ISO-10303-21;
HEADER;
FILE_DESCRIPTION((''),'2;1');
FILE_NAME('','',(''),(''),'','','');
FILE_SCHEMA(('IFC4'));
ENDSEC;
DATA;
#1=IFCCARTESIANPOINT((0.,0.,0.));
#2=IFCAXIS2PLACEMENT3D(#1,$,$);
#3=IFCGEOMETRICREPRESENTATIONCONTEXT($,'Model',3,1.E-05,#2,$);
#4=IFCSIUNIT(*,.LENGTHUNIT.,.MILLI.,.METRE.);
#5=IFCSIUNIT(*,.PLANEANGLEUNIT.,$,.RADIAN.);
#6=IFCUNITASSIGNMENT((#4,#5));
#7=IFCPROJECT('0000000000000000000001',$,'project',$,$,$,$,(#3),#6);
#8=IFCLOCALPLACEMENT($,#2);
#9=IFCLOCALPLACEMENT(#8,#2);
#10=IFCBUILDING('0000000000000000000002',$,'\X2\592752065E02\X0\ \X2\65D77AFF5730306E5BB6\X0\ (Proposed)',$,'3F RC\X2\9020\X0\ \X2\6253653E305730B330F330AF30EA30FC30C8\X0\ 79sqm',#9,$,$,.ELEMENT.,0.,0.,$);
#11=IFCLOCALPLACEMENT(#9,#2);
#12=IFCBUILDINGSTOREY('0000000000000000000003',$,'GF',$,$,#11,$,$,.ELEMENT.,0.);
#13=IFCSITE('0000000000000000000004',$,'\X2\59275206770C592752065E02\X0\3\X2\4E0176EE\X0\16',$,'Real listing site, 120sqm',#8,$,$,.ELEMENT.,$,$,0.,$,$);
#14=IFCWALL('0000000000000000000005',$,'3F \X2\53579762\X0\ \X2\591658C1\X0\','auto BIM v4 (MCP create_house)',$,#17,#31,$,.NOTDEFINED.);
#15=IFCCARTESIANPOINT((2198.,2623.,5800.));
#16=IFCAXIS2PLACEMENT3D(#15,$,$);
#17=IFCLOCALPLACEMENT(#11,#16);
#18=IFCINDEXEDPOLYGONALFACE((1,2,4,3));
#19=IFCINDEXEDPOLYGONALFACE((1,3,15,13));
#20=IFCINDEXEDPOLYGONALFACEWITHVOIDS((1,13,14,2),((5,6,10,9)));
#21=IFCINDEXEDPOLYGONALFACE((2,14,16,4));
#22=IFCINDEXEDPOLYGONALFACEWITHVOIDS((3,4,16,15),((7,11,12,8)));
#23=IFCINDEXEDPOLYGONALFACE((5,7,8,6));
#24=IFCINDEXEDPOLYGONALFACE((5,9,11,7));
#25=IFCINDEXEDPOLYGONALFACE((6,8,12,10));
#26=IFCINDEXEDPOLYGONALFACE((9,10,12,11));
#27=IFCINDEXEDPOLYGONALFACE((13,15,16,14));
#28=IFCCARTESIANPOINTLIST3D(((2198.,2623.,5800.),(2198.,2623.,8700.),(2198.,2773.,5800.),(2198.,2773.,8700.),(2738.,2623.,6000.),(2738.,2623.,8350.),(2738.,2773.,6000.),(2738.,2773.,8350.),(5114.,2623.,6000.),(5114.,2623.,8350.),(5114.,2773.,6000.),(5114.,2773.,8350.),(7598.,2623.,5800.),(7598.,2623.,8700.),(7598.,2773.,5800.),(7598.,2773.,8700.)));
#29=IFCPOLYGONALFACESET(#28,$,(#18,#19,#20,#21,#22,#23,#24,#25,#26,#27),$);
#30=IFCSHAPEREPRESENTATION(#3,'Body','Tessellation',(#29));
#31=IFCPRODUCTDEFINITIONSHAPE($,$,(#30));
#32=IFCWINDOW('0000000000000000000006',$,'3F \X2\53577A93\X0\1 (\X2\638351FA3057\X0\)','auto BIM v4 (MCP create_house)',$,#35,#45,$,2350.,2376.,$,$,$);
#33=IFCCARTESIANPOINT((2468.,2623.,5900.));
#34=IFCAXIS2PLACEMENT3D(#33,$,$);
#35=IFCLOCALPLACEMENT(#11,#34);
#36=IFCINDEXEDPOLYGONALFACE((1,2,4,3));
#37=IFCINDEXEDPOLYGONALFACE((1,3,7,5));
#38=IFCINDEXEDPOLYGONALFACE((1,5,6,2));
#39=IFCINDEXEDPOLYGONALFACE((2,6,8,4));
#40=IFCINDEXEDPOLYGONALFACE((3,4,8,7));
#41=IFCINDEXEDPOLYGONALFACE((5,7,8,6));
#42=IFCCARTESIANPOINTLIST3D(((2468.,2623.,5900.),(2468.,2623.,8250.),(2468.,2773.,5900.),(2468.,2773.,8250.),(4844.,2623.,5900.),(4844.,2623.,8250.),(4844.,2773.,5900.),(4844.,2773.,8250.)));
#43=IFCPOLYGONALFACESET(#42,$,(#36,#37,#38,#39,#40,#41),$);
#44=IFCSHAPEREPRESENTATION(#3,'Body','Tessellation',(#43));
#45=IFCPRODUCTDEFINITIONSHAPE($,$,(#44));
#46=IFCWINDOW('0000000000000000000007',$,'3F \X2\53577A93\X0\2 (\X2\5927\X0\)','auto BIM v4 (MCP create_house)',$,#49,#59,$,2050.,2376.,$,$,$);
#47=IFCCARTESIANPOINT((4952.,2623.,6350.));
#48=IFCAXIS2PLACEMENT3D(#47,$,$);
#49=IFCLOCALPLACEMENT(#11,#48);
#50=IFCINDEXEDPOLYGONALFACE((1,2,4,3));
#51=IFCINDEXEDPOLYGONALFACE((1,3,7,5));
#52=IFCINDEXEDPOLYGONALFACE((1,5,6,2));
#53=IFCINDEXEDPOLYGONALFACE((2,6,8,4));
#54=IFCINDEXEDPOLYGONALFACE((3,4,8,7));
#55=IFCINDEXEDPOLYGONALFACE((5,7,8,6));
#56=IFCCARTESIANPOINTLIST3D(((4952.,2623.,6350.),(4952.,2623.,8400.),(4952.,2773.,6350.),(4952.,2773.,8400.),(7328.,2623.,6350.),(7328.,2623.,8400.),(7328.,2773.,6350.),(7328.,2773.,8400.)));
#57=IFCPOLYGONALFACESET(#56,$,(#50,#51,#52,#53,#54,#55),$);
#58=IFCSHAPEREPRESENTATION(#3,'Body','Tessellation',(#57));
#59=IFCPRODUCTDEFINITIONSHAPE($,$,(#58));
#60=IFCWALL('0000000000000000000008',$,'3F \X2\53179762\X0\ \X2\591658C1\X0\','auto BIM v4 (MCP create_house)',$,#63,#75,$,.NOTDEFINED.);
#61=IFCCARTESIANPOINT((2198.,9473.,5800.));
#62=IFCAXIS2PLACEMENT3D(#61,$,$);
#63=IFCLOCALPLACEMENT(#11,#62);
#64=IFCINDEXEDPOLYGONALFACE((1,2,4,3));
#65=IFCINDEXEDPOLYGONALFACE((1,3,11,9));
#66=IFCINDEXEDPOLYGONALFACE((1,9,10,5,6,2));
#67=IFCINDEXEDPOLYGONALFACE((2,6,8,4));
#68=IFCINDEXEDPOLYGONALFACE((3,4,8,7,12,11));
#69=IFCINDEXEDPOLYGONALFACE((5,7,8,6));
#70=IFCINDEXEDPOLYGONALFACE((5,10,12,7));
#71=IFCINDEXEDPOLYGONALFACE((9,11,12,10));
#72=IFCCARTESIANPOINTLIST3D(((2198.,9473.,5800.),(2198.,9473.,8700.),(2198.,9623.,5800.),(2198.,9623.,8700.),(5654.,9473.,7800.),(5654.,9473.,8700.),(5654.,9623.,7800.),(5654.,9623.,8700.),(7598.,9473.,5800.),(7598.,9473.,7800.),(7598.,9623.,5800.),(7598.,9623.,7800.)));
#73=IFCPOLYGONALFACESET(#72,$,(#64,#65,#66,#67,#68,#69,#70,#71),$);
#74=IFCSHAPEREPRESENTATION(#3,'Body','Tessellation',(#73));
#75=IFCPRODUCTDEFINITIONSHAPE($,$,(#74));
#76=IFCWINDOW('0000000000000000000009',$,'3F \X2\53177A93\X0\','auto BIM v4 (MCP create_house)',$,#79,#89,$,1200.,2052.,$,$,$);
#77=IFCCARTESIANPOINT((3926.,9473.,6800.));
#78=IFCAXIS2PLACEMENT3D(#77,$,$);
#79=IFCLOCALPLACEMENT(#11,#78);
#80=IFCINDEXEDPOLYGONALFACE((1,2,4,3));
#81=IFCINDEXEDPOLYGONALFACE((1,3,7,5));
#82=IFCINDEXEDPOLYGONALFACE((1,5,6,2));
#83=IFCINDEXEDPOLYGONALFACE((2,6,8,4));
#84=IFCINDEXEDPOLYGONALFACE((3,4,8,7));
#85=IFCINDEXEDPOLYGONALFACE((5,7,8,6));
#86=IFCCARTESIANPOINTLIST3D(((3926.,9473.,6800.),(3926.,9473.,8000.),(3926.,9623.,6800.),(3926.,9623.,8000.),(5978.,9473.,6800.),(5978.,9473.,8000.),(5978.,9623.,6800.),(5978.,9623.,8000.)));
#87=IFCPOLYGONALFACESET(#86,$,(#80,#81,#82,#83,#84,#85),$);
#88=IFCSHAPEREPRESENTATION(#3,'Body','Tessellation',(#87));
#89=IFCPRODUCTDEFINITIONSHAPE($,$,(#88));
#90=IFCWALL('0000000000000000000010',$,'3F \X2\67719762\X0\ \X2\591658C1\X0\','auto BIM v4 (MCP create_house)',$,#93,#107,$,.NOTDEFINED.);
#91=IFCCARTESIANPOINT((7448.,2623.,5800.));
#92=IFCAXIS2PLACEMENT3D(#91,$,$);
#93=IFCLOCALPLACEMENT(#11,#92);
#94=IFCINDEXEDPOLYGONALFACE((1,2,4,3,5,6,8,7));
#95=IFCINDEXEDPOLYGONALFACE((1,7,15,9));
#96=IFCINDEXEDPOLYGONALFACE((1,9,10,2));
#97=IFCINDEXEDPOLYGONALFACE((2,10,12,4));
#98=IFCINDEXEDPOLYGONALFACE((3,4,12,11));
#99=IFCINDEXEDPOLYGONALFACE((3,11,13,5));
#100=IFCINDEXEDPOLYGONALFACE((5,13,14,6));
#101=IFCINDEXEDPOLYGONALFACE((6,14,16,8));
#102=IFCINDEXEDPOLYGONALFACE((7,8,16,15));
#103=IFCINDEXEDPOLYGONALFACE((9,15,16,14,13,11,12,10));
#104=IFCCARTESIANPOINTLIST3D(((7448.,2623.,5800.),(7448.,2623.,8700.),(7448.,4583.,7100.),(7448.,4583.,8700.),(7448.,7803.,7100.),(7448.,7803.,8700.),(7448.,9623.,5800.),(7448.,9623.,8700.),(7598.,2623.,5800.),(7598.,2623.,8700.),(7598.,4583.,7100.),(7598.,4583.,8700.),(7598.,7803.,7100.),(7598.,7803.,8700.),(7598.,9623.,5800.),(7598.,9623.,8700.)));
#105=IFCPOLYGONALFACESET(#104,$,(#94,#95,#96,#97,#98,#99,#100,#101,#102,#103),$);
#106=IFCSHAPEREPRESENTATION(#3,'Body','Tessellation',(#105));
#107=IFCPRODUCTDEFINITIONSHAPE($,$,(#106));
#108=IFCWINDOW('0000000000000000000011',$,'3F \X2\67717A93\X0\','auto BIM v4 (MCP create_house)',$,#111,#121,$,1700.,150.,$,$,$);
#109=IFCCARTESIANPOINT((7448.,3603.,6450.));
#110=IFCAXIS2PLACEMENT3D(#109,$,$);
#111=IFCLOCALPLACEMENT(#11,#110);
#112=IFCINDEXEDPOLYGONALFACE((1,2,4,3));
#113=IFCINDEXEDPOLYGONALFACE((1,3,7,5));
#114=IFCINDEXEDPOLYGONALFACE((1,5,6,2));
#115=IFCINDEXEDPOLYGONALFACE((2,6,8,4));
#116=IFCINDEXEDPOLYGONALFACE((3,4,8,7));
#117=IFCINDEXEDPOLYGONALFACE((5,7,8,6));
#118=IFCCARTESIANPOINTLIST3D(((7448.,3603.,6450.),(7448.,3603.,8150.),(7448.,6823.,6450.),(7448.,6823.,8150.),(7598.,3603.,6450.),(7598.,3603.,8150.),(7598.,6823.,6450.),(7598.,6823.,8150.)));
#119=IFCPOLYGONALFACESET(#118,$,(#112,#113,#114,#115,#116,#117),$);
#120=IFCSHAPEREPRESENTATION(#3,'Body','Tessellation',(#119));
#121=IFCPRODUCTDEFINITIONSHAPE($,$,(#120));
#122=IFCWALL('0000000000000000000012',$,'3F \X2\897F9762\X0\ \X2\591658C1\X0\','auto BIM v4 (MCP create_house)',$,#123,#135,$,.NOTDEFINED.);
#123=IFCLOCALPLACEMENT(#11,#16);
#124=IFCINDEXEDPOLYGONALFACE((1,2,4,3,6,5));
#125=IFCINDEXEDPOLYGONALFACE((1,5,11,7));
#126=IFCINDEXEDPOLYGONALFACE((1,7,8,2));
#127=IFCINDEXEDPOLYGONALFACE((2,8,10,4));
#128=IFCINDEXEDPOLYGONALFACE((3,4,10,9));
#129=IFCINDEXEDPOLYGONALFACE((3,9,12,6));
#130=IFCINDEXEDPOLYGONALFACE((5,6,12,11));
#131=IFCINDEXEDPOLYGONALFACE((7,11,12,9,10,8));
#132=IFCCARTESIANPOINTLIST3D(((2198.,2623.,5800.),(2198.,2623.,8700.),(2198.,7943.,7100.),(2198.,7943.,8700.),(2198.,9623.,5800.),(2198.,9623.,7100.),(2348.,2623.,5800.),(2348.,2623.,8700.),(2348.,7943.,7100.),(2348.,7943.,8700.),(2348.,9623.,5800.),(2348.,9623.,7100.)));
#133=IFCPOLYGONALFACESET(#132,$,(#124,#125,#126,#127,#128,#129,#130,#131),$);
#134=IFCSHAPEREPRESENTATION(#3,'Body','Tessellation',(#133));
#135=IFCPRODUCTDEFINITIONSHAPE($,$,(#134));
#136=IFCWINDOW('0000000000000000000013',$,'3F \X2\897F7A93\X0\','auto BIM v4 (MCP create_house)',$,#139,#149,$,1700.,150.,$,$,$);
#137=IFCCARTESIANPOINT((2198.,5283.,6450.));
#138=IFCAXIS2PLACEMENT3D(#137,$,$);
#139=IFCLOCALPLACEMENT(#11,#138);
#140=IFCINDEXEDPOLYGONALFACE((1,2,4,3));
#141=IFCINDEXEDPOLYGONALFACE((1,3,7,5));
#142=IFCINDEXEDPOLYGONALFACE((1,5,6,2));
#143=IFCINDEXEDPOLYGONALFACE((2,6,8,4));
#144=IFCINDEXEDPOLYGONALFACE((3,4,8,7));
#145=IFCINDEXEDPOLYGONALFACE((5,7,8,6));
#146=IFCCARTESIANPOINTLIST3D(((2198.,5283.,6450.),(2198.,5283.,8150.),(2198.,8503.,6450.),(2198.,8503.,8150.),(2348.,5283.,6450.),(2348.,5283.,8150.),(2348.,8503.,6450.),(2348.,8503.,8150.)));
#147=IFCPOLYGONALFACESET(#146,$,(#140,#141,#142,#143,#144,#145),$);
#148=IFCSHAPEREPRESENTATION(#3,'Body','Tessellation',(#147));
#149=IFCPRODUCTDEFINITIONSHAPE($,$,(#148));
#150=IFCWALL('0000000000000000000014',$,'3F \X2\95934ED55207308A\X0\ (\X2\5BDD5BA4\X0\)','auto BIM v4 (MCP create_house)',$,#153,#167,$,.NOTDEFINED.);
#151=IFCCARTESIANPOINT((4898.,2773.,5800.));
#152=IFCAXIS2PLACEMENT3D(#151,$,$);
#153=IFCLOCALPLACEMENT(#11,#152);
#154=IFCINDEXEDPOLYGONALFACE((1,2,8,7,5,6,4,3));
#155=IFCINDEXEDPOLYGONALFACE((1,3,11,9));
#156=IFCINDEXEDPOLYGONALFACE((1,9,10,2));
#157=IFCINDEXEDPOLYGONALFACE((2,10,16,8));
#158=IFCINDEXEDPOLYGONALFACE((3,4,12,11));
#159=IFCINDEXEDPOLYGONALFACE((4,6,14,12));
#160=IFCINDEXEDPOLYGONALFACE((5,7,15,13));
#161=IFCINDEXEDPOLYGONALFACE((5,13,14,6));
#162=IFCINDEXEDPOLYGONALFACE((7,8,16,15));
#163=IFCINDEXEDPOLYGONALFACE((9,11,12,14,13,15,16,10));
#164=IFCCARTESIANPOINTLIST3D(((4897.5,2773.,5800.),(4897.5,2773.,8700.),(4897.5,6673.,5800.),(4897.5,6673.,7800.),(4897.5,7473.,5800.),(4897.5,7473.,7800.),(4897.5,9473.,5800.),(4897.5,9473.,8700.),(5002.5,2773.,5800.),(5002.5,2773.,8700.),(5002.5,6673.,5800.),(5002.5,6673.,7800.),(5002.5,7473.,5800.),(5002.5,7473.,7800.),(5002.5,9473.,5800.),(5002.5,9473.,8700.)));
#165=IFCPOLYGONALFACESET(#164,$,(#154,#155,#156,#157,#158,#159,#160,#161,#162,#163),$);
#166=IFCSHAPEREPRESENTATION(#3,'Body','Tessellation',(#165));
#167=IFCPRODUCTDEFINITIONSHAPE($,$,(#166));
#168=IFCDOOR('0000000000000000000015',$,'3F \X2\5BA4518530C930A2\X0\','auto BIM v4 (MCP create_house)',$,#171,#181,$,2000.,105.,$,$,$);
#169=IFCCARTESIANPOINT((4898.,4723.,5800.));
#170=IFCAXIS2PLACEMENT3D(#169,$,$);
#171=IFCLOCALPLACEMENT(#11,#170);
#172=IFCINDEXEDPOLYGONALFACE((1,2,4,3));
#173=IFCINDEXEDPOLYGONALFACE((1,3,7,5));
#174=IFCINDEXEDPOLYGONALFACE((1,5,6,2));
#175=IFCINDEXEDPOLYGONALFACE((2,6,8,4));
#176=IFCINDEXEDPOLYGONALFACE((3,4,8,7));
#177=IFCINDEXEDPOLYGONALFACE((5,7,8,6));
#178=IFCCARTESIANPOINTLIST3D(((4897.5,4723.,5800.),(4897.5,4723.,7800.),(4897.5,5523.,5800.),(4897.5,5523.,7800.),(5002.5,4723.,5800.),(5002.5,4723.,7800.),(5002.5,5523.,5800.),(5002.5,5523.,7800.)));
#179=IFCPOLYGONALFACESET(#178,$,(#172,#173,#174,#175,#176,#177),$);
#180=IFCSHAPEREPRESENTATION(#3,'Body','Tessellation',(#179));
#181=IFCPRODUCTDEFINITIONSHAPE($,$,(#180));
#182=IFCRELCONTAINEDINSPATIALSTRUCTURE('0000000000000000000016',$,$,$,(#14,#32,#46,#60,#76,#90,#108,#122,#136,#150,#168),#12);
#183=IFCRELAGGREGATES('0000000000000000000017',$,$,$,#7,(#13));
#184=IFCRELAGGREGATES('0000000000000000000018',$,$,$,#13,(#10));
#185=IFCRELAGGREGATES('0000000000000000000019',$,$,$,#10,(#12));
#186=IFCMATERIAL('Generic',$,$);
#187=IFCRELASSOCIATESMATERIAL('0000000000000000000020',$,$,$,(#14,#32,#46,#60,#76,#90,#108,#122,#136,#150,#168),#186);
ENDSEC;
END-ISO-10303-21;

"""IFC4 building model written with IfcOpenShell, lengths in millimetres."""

from ifc_helpers import new_model, si_unit, frame, frame_2d, origin, place, context, project, spatial, rectangle, extrude, material, element, fill, save


model = new_model("IFC4")

# Units and contexts
model_context = context("Model", 3, precision=1e-05, world=origin())
ifc_project = project(units=[si_unit("LENGTHUNIT", "METRE", prefix="MILLI"), si_unit("PLANEANGLEUNIT", "RADIAN")], contexts=[model_context])

# Site, building, storey
site_placement = place(None, origin())
site = spatial("IfcSite", under=ifc_project, at=site_placement, Name="大分県大分市3丁目16", ObjectType="Real listing site, 120sqm", CompositionType="ELEMENT", RefElevation=0.0)
building_placement = place(site_placement, origin())
building = spatial("IfcBuilding", under=site, at=building_placement, Name="大分市 旗竿地の家 (Proposed)", ObjectType="3F RC造 打放しコンクリート 79sqm", CompositionType="ELEMENT", ElevationOfRefHeight=0.0, ElevationOfTerrain=0.0)
storey_placement = place(building_placement, origin())
storey = spatial("IfcBuildingStorey", under=building, at=storey_placement, Name="GF", CompositionType="ELEMENT", Elevation=0.0)

# Shared definitions
ifc_material = material(Name="Generic")

# Wall, openings, windows
wall_1_placement = place(storey_placement, frame((2198.0, 2623.0, 5800.0)))
wall_1 = element("IfcWall", 1, at=wall_1_placement, inside=storey, material=ifc_material, Name="3F 南面 外壁", Description="auto BIM v4 (MCP create_house)", PredefinedType="NOTDEFINED", context=model_context, shape_type="SweptSolid", body=[
    extrude(rectangle(XDim=5400.0, YDim=150.0, at=frame_2d((2700.0, 75.0))), frame((2198.0, 2623.0, 5800.0)), (0.0, 0.0, 1.0), 2900.0),
])
opening_1_placement = place(storey_placement, frame((2468.0, 2623.0, 5900.0)))
opening_1 = element("IfcOpeningElement", 2, at=opening_1_placement, cuts=wall_1, PredefinedType="NOTDEFINED", context=model_context, shape_type="SweptSolid", body=[
    extrude(rectangle(XDim=2376.0, YDim=150.0, at=frame_2d((1188.0, 75.0))), frame((2468.0, 2623.0, 5900.0)), (0.0, 0.0, 1.0), 2350.0),
])
opening_2_placement = place(storey_placement, frame((4952.0, 2623.0, 6350.0)))
opening_2 = element("IfcOpeningElement", 3, at=opening_2_placement, cuts=wall_1, PredefinedType="NOTDEFINED", context=model_context, shape_type="SweptSolid", body=[
    extrude(rectangle(XDim=2376.0, YDim=150.0, at=frame_2d((1188.0, 75.0))), frame((4952.0, 2623.0, 6350.0)), (0.0, 0.0, 1.0), 2050.0),
])
window_1_placement = place(storey_placement, frame((2468.0, 2623.0, 5900.0)))
window_1 = element("IfcWindow", 4, at=window_1_placement, inside=storey, material=ifc_material, Name="3F 南窓1 (掃出し)", Description="auto BIM v4 (MCP create_house)", OverallHeight=2350.0, OverallWidth=2376.0, context=model_context, shape_type="SweptSolid", body=[
    extrude(rectangle(XDim=2376.0, YDim=150.0, at=frame_2d((1188.0, 75.0))), frame((2468.0, 2623.0, 5900.0)), (0.0, 0.0, 1.0), 2350.0),
])
fill(opening_1, window_1)
window_2_placement = place(storey_placement, frame((4952.0, 2623.0, 6350.0)))
window_2 = element("IfcWindow", 5, at=window_2_placement, inside=storey, material=ifc_material, Name="3F 南窓2 (大)", Description="auto BIM v4 (MCP create_house)", OverallHeight=2050.0, OverallWidth=2376.0, context=model_context, shape_type="SweptSolid", body=[
    extrude(rectangle(XDim=2376.0, YDim=150.0, at=frame_2d((1188.0, 75.0))), frame((4952.0, 2623.0, 6350.0)), (0.0, 0.0, 1.0), 2050.0),
])
fill(opening_2, window_2)

# Walls, openings, windows
wall_2_placement = place(storey_placement, frame((2198.0, 9473.0, 5800.0)))
wall_2 = element("IfcWall", 6, at=wall_2_placement, inside=storey, material=ifc_material, Name="3F 北面 外壁", Description="auto BIM v4 (MCP create_house)", PredefinedType="NOTDEFINED", context=model_context, shape_type="SweptSolid", body=[
    extrude(rectangle(XDim=5400.0, YDim=150.0, at=frame_2d((2700.0, 75.0))), frame((2198.0, 9473.0, 5800.0)), (0.0, 0.0, 1.0), 2900.0),
])
opening_3_placement = place(storey_placement, frame((3926.0, 9473.0, 6800.0)))
opening_3 = element("IfcOpeningElement", 7, at=opening_3_placement, cuts=wall_2, PredefinedType="NOTDEFINED", context=model_context, shape_type="SweptSolid", body=[
    extrude(rectangle(XDim=2052.0, YDim=150.0, at=frame_2d((1026.0, 75.0))), frame((3926.0, 9473.0, 6800.0)), (0.0, 0.0, 1.0), 1200.0),
])
window_3_placement = place(storey_placement, frame((3926.0, 9473.0, 6800.0)))
window_3 = element("IfcWindow", 8, at=window_3_placement, inside=storey, material=ifc_material, Name="3F 北窓", Description="auto BIM v4 (MCP create_house)", OverallHeight=1200.0, OverallWidth=2052.0, context=model_context, shape_type="SweptSolid", body=[
    extrude(rectangle(XDim=2052.0, YDim=150.0, at=frame_2d((1026.0, 75.0))), frame((3926.0, 9473.0, 6800.0)), (0.0, 0.0, 1.0), 1200.0),
])
fill(opening_3, window_3)
wall_3_placement = place(storey_placement, frame((7448.0, 2623.0, 5800.0)))
wall_3 = element("IfcWall", 9, at=wall_3_placement, inside=storey, material=ifc_material, Name="3F 東面 外壁", Description="auto BIM v4 (MCP create_house)", PredefinedType="NOTDEFINED", context=model_context, shape_type="SweptSolid", body=[
    extrude(rectangle(XDim=150.0, YDim=7000.0, at=frame_2d((75.0, 3500.0))), frame((7448.0, 2623.0, 5800.0)), (0.0, 0.0, 1.0), 2900.0),
])
opening_4_placement = place(storey_placement, frame((7448.0, 3603.0, 6450.0)))
opening_4 = element("IfcOpeningElement", 10, at=opening_4_placement, cuts=wall_3, PredefinedType="NOTDEFINED", context=model_context, shape_type="SweptSolid", body=[
    extrude(rectangle(XDim=150.0, YDim=3220.0, at=frame_2d((75.0, 1610.0))), frame((7448.0, 3603.0, 6450.0)), (0.0, 0.0, 1.0), 1700.0),
])
window_4_placement = place(storey_placement, frame((7448.0, 3603.0, 6450.0)))
window_4 = element("IfcWindow", 11, at=window_4_placement, inside=storey, material=ifc_material, Name="3F 東窓", Description="auto BIM v4 (MCP create_house)", OverallHeight=1700.0, OverallWidth=150.0, context=model_context, shape_type="SweptSolid", body=[
    extrude(rectangle(XDim=150.0, YDim=3220.0, at=frame_2d((75.0, 1610.0))), frame((7448.0, 3603.0, 6450.0)), (0.0, 0.0, 1.0), 1700.0),
])
fill(opening_4, window_4)
wall_4_placement = place(storey_placement, frame((2198.0, 2623.0, 5800.0)))
wall_4 = element("IfcWall", 12, at=wall_4_placement, inside=storey, material=ifc_material, Name="3F 西面 外壁", Description="auto BIM v4 (MCP create_house)", PredefinedType="NOTDEFINED", context=model_context, shape_type="SweptSolid", body=[
    extrude(rectangle(XDim=150.0, YDim=7000.0, at=frame_2d((75.0, 3500.0))), frame((2198.0, 2623.0, 5800.0)), (0.0, 0.0, 1.0), 2900.0),
])
opening_5_placement = place(storey_placement, frame((2198.0, 5283.0, 6450.0)))
opening_5 = element("IfcOpeningElement", 13, at=opening_5_placement, cuts=wall_4, PredefinedType="NOTDEFINED", context=model_context, shape_type="SweptSolid", body=[
    extrude(rectangle(XDim=150.0, YDim=3220.0, at=frame_2d((75.0, 1610.0))), frame((2198.0, 5283.0, 6450.0)), (0.0, 0.0, 1.0), 1700.0),
])
window_5_placement = place(storey_placement, frame((2198.0, 5283.0, 6450.0)))
window_5 = element("IfcWindow", 14, at=window_5_placement, inside=storey, material=ifc_material, Name="3F 西窓", Description="auto BIM v4 (MCP create_house)", OverallHeight=1700.0, OverallWidth=150.0, context=model_context, shape_type="SweptSolid", body=[
    extrude(rectangle(XDim=150.0, YDim=3220.0, at=frame_2d((75.0, 1610.0))), frame((2198.0, 5283.0, 6450.0)), (0.0, 0.0, 1.0), 1700.0),
])
fill(opening_5, window_5)

# Wall, opening, door
wall_5_placement = place(storey_placement, frame((4898.0, 2773.0, 5800.0)))
wall_5 = element("IfcWall", 15, at=wall_5_placement, inside=storey, material=ifc_material, Name="3F 間仕切り (寝室)", Description="auto BIM v4 (MCP create_house)", PredefinedType="NOTDEFINED", context=model_context, shape_type="SweptSolid", body=[
    extrude(rectangle(XDim=105.0, YDim=6700.0, at=frame_2d((52.0, 3350.0))), frame((4898.0, 2773.0, 5800.0)), (0.0, 0.0, 1.0), 2900.0),
])
opening_6_placement = place(storey_placement, frame((4898.0, 4723.0, 5800.0)))
opening_6 = element("IfcOpeningElement", 16, at=opening_6_placement, cuts=wall_5, PredefinedType="NOTDEFINED", context=model_context, shape_type="SweptSolid", body=[
    extrude(rectangle(XDim=105.0, YDim=800.0, at=frame_2d((52.0, 400.0))), frame((4898.0, 4723.0, 5800.0)), (0.0, 0.0, 1.0), 2000.0),
])
door_1_placement = place(storey_placement, frame((4898.0, 4723.0, 5800.0)))
door_1 = element("IfcDoor", 17, at=door_1_placement, inside=storey, material=ifc_material, Name="3F 室内ドア", Description="auto BIM v4 (MCP create_house)", OverallHeight=2000.0, OverallWidth=105.0, context=model_context, shape_type="SweptSolid", body=[
    extrude(rectangle(XDim=105.0, YDim=800.0, at=frame_2d((52.0, 400.0))), frame((4898.0, 4723.0, 5800.0)), (0.0, 0.0, 1.0), 2000.0),
])
fill(opening_6, door_1)

save(model, "model.ifc")
